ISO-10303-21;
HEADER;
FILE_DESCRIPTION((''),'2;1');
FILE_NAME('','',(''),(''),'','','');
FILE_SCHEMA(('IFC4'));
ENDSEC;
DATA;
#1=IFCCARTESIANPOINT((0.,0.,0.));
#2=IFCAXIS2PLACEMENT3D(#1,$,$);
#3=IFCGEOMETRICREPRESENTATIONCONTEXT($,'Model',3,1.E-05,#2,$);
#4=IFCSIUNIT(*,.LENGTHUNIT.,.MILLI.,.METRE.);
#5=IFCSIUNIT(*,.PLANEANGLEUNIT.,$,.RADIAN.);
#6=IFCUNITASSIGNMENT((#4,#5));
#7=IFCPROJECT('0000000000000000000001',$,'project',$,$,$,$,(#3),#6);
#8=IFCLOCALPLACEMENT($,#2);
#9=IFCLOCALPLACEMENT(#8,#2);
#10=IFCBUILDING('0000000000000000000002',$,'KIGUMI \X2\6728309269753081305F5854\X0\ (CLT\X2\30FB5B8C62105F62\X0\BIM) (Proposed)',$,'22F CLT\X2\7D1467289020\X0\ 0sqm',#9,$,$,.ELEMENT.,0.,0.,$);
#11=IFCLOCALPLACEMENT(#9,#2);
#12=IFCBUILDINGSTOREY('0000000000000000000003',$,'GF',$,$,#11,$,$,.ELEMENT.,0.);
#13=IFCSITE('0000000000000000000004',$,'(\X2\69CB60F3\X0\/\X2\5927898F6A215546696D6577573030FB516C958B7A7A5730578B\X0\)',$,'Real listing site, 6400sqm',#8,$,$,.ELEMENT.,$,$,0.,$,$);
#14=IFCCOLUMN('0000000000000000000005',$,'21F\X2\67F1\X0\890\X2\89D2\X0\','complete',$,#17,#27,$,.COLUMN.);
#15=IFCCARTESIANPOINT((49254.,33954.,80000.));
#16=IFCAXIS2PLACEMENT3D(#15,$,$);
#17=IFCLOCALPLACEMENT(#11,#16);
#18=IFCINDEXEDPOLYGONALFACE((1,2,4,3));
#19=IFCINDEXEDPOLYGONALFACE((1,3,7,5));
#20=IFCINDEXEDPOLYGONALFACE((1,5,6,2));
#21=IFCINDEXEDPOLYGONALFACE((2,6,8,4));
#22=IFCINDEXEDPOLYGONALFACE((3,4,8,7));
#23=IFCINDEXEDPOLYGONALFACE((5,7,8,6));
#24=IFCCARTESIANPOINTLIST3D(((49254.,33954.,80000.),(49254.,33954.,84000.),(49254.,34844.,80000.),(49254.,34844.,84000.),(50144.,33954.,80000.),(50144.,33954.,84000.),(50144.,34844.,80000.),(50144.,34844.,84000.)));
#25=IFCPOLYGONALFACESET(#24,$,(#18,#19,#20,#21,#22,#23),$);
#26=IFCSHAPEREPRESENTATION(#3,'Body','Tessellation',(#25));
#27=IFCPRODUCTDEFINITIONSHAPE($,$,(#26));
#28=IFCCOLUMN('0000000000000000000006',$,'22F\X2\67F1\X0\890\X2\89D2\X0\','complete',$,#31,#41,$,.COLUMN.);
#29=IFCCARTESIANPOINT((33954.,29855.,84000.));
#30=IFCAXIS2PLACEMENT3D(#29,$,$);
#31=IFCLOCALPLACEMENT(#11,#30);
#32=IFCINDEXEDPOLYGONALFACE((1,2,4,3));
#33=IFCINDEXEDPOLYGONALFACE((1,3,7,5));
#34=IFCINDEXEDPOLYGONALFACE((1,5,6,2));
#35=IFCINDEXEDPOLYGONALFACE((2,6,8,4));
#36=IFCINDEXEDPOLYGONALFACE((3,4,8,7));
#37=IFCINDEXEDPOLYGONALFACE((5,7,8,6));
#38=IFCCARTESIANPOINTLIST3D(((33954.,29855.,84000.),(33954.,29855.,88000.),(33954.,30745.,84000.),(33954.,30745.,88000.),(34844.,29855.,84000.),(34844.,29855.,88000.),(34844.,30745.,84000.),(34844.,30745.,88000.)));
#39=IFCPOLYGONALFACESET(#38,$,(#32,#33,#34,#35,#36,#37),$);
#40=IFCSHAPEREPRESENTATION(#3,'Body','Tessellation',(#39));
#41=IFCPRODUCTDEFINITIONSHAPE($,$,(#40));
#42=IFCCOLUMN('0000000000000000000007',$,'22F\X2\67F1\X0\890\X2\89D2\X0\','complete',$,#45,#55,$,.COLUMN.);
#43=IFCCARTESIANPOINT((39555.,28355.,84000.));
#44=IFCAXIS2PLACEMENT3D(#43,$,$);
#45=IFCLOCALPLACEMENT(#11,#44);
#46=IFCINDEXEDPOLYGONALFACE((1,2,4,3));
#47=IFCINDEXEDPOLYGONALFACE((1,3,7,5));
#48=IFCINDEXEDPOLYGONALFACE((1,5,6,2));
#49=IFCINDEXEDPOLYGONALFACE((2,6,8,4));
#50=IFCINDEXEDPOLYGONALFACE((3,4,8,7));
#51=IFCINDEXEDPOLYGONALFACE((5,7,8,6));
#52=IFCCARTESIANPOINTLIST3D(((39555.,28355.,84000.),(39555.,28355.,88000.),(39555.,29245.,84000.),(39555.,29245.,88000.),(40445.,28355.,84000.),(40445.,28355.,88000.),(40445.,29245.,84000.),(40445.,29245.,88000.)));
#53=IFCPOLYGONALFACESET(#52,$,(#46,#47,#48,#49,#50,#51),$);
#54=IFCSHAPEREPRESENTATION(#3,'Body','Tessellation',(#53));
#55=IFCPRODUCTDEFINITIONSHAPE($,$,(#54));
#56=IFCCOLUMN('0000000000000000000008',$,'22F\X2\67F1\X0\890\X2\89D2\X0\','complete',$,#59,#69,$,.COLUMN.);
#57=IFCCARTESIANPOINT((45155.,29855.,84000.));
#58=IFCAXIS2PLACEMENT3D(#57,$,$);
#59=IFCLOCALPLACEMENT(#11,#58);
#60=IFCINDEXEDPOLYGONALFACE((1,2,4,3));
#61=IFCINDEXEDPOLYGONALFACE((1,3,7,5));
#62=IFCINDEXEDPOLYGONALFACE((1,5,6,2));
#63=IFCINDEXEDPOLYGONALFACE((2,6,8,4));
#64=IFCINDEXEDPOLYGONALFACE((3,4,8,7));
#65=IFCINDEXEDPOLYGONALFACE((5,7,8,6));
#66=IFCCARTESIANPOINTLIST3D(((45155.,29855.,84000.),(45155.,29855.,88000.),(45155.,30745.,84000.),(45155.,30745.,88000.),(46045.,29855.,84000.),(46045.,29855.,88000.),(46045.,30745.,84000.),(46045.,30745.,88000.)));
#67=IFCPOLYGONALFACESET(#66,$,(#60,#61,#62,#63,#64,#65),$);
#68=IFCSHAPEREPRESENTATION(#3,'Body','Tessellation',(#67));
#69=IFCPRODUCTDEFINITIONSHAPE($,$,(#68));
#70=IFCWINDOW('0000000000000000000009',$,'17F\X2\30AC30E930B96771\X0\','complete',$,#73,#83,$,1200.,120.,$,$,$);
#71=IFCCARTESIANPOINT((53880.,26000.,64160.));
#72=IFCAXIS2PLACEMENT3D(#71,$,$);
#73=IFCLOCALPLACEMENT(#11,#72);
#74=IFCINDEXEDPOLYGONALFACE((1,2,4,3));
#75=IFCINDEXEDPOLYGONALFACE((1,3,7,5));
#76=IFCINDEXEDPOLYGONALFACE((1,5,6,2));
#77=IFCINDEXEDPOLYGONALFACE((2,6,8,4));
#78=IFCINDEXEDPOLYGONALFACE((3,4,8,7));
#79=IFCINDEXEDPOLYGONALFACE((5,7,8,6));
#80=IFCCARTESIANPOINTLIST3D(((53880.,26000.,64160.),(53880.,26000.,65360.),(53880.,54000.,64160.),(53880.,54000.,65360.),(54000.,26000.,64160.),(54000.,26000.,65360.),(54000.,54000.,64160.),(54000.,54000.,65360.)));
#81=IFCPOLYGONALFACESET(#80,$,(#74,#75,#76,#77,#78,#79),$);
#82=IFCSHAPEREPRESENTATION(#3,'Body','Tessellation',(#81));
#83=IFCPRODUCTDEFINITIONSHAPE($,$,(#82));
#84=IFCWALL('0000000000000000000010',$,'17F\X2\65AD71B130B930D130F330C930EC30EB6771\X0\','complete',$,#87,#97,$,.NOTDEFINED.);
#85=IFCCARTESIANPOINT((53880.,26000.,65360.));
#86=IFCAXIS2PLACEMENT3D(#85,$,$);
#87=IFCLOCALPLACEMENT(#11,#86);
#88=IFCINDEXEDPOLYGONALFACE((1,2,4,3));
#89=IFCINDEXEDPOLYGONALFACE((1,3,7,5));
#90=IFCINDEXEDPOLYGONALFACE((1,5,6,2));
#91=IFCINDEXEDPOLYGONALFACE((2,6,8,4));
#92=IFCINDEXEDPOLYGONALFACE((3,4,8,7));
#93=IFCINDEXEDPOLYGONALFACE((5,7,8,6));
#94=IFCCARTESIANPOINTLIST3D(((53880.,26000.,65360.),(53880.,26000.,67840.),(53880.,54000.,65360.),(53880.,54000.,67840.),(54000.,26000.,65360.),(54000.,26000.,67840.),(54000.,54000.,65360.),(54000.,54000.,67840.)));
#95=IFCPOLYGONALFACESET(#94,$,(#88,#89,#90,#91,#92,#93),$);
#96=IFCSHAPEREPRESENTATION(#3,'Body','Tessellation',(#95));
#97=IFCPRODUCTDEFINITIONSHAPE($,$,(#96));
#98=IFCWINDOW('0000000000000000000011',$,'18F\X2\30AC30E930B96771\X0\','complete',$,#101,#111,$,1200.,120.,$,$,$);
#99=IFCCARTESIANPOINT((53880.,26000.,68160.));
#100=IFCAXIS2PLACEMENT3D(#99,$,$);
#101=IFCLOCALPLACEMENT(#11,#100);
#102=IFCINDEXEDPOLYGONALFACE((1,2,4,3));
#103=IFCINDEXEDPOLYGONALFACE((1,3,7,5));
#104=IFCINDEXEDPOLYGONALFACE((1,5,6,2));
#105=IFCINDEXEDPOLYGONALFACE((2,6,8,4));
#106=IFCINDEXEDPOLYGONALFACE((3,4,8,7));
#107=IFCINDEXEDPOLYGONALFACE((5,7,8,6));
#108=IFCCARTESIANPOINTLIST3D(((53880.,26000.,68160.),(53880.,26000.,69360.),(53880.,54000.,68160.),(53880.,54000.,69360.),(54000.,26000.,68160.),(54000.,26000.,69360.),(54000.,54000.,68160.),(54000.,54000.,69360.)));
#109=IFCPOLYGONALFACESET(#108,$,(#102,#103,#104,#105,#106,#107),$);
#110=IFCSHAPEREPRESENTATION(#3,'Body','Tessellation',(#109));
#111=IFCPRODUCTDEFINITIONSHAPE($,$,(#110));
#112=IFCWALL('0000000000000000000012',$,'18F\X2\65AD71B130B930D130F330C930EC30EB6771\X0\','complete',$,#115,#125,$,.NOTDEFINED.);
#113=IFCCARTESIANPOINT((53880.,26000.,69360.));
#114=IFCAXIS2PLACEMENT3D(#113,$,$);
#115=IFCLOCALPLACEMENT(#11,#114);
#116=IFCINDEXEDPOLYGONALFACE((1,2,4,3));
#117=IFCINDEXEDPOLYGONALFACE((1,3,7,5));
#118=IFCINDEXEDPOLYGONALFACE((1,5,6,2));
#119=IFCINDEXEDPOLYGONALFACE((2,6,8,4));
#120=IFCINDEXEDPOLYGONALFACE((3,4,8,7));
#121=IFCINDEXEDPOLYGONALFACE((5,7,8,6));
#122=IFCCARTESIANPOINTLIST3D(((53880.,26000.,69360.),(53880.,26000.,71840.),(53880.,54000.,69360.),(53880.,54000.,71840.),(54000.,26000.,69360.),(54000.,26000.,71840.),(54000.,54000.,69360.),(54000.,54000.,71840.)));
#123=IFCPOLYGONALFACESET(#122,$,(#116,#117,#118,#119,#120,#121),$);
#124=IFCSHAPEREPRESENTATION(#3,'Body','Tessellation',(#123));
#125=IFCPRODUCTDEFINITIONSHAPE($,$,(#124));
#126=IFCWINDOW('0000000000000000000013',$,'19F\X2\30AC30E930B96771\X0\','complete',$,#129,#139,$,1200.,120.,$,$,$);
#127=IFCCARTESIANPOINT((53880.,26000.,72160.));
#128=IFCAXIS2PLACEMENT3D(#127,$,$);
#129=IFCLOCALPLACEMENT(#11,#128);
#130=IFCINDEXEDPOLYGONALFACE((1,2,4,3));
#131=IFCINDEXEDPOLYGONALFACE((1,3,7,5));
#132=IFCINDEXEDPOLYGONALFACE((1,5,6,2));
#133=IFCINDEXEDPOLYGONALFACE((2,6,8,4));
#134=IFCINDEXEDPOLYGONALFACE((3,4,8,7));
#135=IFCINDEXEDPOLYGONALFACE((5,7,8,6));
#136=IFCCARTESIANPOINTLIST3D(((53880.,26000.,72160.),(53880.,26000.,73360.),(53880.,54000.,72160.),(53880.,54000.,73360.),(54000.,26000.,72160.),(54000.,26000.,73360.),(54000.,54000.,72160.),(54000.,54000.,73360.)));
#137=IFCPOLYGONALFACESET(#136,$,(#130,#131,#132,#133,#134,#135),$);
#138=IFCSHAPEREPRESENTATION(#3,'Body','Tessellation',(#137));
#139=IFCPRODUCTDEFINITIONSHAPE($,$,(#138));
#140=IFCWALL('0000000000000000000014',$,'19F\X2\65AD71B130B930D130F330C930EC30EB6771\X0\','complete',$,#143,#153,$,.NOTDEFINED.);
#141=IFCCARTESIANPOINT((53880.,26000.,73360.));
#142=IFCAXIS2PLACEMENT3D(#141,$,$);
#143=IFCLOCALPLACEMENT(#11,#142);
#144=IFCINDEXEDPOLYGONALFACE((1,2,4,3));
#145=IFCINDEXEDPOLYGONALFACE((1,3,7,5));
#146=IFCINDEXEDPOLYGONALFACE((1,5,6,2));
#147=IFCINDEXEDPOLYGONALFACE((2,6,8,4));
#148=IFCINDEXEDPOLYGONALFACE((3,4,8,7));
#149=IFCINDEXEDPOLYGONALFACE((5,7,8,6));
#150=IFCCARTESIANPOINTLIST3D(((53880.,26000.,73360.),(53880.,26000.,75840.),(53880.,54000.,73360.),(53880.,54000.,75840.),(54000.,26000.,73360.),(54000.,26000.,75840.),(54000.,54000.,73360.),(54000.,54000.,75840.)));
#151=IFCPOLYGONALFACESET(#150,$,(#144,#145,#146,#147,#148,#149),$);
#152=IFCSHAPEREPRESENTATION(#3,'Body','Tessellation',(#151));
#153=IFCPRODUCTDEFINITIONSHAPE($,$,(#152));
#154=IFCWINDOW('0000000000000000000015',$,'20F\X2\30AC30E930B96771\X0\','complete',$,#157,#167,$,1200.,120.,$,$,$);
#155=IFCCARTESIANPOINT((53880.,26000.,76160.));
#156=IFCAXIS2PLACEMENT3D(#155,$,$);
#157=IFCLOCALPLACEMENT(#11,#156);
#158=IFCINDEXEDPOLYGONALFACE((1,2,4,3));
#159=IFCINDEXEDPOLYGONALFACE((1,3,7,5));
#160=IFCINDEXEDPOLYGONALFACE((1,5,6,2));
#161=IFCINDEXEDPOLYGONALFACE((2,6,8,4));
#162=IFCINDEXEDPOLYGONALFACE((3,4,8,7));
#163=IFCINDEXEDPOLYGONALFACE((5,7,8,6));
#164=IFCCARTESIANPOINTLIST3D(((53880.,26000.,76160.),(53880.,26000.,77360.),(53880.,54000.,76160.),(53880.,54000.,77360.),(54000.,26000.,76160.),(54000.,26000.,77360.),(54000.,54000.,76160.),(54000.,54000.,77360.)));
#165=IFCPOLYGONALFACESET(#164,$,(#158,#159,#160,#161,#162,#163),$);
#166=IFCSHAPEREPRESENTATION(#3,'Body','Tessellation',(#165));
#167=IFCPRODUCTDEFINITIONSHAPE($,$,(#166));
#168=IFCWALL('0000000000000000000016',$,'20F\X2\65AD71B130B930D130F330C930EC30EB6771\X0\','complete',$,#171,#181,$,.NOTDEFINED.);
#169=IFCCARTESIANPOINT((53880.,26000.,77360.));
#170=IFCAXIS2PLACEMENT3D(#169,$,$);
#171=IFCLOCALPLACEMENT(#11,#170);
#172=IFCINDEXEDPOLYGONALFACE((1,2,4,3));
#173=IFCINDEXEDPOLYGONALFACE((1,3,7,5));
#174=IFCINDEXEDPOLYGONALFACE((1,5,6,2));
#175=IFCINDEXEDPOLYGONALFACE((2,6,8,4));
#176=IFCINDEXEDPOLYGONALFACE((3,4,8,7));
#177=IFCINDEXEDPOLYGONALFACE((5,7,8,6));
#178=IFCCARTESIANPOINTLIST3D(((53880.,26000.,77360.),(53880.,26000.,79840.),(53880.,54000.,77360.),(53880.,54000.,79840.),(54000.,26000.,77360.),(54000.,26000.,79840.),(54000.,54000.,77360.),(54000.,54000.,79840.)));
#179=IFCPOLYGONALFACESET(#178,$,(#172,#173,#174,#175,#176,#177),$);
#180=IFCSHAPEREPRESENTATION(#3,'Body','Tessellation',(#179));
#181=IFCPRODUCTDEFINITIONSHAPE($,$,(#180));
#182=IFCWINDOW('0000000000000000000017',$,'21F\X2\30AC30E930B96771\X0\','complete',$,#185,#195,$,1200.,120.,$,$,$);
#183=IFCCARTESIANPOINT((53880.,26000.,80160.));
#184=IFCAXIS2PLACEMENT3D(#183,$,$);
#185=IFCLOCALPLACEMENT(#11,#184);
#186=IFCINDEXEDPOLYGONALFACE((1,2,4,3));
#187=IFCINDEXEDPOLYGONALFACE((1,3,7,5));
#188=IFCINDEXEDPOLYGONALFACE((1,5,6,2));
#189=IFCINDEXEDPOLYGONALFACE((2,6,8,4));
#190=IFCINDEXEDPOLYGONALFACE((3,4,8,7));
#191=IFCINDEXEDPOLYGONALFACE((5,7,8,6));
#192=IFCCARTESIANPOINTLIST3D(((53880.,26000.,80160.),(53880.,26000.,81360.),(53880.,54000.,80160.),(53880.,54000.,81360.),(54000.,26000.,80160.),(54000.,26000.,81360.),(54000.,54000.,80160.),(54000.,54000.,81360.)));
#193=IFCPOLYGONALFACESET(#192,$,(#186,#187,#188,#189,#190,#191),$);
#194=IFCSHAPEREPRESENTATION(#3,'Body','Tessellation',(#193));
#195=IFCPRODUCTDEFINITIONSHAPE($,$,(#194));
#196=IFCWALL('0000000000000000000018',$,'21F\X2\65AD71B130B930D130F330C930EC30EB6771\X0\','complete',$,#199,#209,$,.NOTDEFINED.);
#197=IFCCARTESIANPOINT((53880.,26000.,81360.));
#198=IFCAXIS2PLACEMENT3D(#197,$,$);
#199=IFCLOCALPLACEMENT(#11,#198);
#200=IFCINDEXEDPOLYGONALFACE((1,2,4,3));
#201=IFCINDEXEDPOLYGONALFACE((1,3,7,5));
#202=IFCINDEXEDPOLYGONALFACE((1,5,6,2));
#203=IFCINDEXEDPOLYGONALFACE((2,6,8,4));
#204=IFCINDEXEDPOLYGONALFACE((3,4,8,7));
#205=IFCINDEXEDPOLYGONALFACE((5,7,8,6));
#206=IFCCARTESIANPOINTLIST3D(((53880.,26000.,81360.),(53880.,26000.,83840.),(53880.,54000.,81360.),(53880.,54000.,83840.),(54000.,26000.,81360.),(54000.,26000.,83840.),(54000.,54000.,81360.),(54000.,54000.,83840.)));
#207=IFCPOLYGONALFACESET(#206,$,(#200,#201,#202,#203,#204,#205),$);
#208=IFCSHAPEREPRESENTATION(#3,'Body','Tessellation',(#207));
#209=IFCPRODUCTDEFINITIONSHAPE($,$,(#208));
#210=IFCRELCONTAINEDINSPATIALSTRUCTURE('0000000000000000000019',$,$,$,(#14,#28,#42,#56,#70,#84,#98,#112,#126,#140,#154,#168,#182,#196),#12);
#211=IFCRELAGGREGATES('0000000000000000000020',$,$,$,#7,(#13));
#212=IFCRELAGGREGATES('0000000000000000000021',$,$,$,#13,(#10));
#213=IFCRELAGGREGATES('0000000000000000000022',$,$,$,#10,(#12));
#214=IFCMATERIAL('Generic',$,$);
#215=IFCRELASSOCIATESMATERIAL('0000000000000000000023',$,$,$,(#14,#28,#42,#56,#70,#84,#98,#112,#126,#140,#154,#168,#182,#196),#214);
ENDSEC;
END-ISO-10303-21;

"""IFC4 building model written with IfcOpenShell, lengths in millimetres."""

from ifc_helpers import new_model, si_unit, frame, frame_2d, origin, place, context, project, spatial, rectangle, extrude, material, element, save


model = new_model("IFC4")

# Units and contexts
model_context = context("Model", 3, precision=1e-05, world=origin())
ifc_project = project(units=[si_unit("LENGTHUNIT", "METRE", prefix="MILLI"), si_unit("PLANEANGLEUNIT", "RADIAN")], contexts=[model_context])

# Site, building, storey
site_placement = place(None, origin())
site = spatial("IfcSite", under=ifc_project, at=site_placement, Name="(構想/大規模商業敷地・公開空地型)", ObjectType="Real listing site, 6400sqm", CompositionType="ELEMENT", RefElevation=0.0)
building_placement = place(site_placement, origin())
building = spatial("IfcBuilding", under=site, at=building_placement, Name="KIGUMI 木を極めた塔 (CLT・完成形BIM) (Proposed)", ObjectType="22F CLT純木造 0sqm", CompositionType="ELEMENT", ElevationOfRefHeight=0.0, ElevationOfTerrain=0.0)
storey_placement = place(building_placement, origin())
storey = spatial("IfcBuildingStorey", under=building, at=storey_placement, Name="GF", CompositionType="ELEMENT", Elevation=0.0)

# Columns
ifc_material = material(Name="Generic")
column_1_placement = place(storey_placement, frame((49254.0, 33954.0, 80000.0)))
element("IfcColumn", 1, at=column_1_placement, inside=storey, material=ifc_material, Name="21F柱890角", Description="complete", PredefinedType="COLUMN", context=model_context, shape_type="SweptSolid", body=[
    extrude(rectangle(XDim=890.0, YDim=890.0, at=frame_2d((445.0, 445.0))), frame((49254.0, 33954.0, 80000.0)), (0.0, 0.0, 1.0), 4000.0),
])
column_2_placement = place(storey_placement, frame((33954.0, 29855.0, 84000.0)))
element("IfcColumn", 2, at=column_2_placement, inside=storey, material=ifc_material, Name="22F柱890角", Description="complete", PredefinedType="COLUMN", context=model_context, shape_type="SweptSolid", body=[
    extrude(rectangle(XDim=890.0, YDim=890.0, at=frame_2d((445.0, 445.0))), frame((33954.0, 29855.0, 84000.0)), (0.0, 0.0, 1.0), 4000.0),
])
column_3_placement = place(storey_placement, frame((39555.0, 28355.0, 84000.0)))
element("IfcColumn", 3, at=column_3_placement, inside=storey, material=ifc_material, Name="22F柱890角", Description="complete", PredefinedType="COLUMN", context=model_context, shape_type="SweptSolid", body=[
    extrude(rectangle(XDim=890.0, YDim=890.0, at=frame_2d((445.0, 445.0))), frame((39555.0, 28355.0, 84000.0)), (0.0, 0.0, 1.0), 4000.0),
])
column_4_placement = place(storey_placement, frame((45155.0, 29855.0, 84000.0)))
element("IfcColumn", 4, at=column_4_placement, inside=storey, material=ifc_material, Name="22F柱890角", Description="complete", PredefinedType="COLUMN", context=model_context, shape_type="SweptSolid", body=[
    extrude(rectangle(XDim=890.0, YDim=890.0, at=frame_2d((445.0, 445.0))), frame((45155.0, 29855.0, 84000.0)), (0.0, 0.0, 1.0), 4000.0),
])

# Window
window_1_placement = place(storey_placement, frame((53880.0, 26000.0, 64160.0)))
element("IfcWindow", 5, at=window_1_placement, inside=storey, material=ifc_material, Name="17Fガラス東", Description="complete", OverallHeight=1200.0, OverallWidth=120.0, context=model_context, shape_type="SweptSolid", body=[
    extrude(rectangle(XDim=120.0, YDim=28000.0, at=frame_2d((60.0, 14000.0))), frame((53880.0, 26000.0, 64160.0)), (0.0, 0.0, 1.0), 1200.0),
])

# Wall
wall_1_placement = place(storey_placement, frame((53880.0, 26000.0, 65360.0)))
element("IfcWall", 6, at=wall_1_placement, inside=storey, material=ifc_material, Name="17F断熱スパンドレル東", Description="complete", PredefinedType="NOTDEFINED", context=model_context, shape_type="SweptSolid", body=[
    extrude(rectangle(XDim=120.0, YDim=28000.0, at=frame_2d((60.0, 14000.0))), frame((53880.0, 26000.0, 65360.0)), (0.0, 0.0, 1.0), 2480.0),
])

# Window
window_2_placement = place(storey_placement, frame((53880.0, 26000.0, 68160.0)))
element("IfcWindow", 7, at=window_2_placement, inside=storey, material=ifc_material, Name="18Fガラス東", Description="complete", OverallHeight=1200.0, OverallWidth=120.0, context=model_context, shape_type="SweptSolid", body=[
    extrude(rectangle(XDim=120.0, YDim=28000.0, at=frame_2d((60.0, 14000.0))), frame((53880.0, 26000.0, 68160.0)), (0.0, 0.0, 1.0), 1200.0),
])

# Wall
wall_2_placement = place(storey_placement, frame((53880.0, 26000.0, 69360.0)))
element("IfcWall", 8, at=wall_2_placement, inside=storey, material=ifc_material, Name="18F断熱スパンドレル東", Description="complete", PredefinedType="NOTDEFINED", context=model_context, shape_type="SweptSolid", body=[
    extrude(rectangle(XDim=120.0, YDim=28000.0, at=frame_2d((60.0, 14000.0))), frame((53880.0, 26000.0, 69360.0)), (0.0, 0.0, 1.0), 2480.0),
])

# Window
window_3_placement = place(storey_placement, frame((53880.0, 26000.0, 72160.0)))
element("IfcWindow", 9, at=window_3_placement, inside=storey, material=ifc_material, Name="19Fガラス東", Description="complete", OverallHeight=1200.0, OverallWidth=120.0, context=model_context, shape_type="SweptSolid", body=[
    extrude(rectangle(XDim=120.0, YDim=28000.0, at=frame_2d((60.0, 14000.0))), frame((53880.0, 26000.0, 72160.0)), (0.0, 0.0, 1.0), 1200.0),
])

# Wall
wall_3_placement = place(storey_placement, frame((53880.0, 26000.0, 73360.0)))
element("IfcWall", 10, at=wall_3_placement, inside=storey, material=ifc_material, Name="19F断熱スパンドレル東", Description="complete", PredefinedType="NOTDEFINED", context=model_context, shape_type="SweptSolid", body=[
    extrude(rectangle(XDim=120.0, YDim=28000.0, at=frame_2d((60.0, 14000.0))), frame((53880.0, 26000.0, 73360.0)), (0.0, 0.0, 1.0), 2480.0),
])

# Window
window_4_placement = place(storey_placement, frame((53880.0, 26000.0, 76160.0)))
element("IfcWindow", 11, at=window_4_placement, inside=storey, material=ifc_material, Name="20Fガラス東", Description="complete", OverallHeight=1200.0, OverallWidth=120.0, context=model_context, shape_type="SweptSolid", body=[
    extrude(rectangle(XDim=120.0, YDim=28000.0, at=frame_2d((60.0, 14000.0))), frame((53880.0, 26000.0, 76160.0)), (0.0, 0.0, 1.0), 1200.0),
])

# Wall
wall_4_placement = place(storey_placement, frame((53880.0, 26000.0, 77360.0)))
element("IfcWall", 12, at=wall_4_placement, inside=storey, material=ifc_material, Name="20F断熱スパンドレル東", Description="complete", PredefinedType="NOTDEFINED", context=model_context, shape_type="SweptSolid", body=[
    extrude(rectangle(XDim=120.0, YDim=28000.0, at=frame_2d((60.0, 14000.0))), frame((53880.0, 26000.0, 77360.0)), (0.0, 0.0, 1.0), 2480.0),
])

# Window
window_5_placement = place(storey_placement, frame((53880.0, 26000.0, 80160.0)))
element("IfcWindow", 13, at=window_5_placement, inside=storey, material=ifc_material, Name="21Fガラス東", Description="complete", OverallHeight=1200.0, OverallWidth=120.0, context=model_context, shape_type="SweptSolid", body=[
    extrude(rectangle(XDim=120.0, YDim=28000.0, at=frame_2d((60.0, 14000.0))), frame((53880.0, 26000.0, 80160.0)), (0.0, 0.0, 1.0), 1200.0),
])

# Wall
wall_5_placement = place(storey_placement, frame((53880.0, 26000.0, 81360.0)))
element("IfcWall", 14, at=wall_5_placement, inside=storey, material=ifc_material, Name="21F断熱スパンドレル東", Description="complete", PredefinedType="NOTDEFINED", context=model_context, shape_type="SweptSolid", body=[
    extrude(rectangle(XDim=120.0, YDim=28000.0, at=frame_2d((60.0, 14000.0))), frame((53880.0, 26000.0, 81360.0)), (0.0, 0.0, 1.0), 2480.0),
])

save(model, "model.ifc")
